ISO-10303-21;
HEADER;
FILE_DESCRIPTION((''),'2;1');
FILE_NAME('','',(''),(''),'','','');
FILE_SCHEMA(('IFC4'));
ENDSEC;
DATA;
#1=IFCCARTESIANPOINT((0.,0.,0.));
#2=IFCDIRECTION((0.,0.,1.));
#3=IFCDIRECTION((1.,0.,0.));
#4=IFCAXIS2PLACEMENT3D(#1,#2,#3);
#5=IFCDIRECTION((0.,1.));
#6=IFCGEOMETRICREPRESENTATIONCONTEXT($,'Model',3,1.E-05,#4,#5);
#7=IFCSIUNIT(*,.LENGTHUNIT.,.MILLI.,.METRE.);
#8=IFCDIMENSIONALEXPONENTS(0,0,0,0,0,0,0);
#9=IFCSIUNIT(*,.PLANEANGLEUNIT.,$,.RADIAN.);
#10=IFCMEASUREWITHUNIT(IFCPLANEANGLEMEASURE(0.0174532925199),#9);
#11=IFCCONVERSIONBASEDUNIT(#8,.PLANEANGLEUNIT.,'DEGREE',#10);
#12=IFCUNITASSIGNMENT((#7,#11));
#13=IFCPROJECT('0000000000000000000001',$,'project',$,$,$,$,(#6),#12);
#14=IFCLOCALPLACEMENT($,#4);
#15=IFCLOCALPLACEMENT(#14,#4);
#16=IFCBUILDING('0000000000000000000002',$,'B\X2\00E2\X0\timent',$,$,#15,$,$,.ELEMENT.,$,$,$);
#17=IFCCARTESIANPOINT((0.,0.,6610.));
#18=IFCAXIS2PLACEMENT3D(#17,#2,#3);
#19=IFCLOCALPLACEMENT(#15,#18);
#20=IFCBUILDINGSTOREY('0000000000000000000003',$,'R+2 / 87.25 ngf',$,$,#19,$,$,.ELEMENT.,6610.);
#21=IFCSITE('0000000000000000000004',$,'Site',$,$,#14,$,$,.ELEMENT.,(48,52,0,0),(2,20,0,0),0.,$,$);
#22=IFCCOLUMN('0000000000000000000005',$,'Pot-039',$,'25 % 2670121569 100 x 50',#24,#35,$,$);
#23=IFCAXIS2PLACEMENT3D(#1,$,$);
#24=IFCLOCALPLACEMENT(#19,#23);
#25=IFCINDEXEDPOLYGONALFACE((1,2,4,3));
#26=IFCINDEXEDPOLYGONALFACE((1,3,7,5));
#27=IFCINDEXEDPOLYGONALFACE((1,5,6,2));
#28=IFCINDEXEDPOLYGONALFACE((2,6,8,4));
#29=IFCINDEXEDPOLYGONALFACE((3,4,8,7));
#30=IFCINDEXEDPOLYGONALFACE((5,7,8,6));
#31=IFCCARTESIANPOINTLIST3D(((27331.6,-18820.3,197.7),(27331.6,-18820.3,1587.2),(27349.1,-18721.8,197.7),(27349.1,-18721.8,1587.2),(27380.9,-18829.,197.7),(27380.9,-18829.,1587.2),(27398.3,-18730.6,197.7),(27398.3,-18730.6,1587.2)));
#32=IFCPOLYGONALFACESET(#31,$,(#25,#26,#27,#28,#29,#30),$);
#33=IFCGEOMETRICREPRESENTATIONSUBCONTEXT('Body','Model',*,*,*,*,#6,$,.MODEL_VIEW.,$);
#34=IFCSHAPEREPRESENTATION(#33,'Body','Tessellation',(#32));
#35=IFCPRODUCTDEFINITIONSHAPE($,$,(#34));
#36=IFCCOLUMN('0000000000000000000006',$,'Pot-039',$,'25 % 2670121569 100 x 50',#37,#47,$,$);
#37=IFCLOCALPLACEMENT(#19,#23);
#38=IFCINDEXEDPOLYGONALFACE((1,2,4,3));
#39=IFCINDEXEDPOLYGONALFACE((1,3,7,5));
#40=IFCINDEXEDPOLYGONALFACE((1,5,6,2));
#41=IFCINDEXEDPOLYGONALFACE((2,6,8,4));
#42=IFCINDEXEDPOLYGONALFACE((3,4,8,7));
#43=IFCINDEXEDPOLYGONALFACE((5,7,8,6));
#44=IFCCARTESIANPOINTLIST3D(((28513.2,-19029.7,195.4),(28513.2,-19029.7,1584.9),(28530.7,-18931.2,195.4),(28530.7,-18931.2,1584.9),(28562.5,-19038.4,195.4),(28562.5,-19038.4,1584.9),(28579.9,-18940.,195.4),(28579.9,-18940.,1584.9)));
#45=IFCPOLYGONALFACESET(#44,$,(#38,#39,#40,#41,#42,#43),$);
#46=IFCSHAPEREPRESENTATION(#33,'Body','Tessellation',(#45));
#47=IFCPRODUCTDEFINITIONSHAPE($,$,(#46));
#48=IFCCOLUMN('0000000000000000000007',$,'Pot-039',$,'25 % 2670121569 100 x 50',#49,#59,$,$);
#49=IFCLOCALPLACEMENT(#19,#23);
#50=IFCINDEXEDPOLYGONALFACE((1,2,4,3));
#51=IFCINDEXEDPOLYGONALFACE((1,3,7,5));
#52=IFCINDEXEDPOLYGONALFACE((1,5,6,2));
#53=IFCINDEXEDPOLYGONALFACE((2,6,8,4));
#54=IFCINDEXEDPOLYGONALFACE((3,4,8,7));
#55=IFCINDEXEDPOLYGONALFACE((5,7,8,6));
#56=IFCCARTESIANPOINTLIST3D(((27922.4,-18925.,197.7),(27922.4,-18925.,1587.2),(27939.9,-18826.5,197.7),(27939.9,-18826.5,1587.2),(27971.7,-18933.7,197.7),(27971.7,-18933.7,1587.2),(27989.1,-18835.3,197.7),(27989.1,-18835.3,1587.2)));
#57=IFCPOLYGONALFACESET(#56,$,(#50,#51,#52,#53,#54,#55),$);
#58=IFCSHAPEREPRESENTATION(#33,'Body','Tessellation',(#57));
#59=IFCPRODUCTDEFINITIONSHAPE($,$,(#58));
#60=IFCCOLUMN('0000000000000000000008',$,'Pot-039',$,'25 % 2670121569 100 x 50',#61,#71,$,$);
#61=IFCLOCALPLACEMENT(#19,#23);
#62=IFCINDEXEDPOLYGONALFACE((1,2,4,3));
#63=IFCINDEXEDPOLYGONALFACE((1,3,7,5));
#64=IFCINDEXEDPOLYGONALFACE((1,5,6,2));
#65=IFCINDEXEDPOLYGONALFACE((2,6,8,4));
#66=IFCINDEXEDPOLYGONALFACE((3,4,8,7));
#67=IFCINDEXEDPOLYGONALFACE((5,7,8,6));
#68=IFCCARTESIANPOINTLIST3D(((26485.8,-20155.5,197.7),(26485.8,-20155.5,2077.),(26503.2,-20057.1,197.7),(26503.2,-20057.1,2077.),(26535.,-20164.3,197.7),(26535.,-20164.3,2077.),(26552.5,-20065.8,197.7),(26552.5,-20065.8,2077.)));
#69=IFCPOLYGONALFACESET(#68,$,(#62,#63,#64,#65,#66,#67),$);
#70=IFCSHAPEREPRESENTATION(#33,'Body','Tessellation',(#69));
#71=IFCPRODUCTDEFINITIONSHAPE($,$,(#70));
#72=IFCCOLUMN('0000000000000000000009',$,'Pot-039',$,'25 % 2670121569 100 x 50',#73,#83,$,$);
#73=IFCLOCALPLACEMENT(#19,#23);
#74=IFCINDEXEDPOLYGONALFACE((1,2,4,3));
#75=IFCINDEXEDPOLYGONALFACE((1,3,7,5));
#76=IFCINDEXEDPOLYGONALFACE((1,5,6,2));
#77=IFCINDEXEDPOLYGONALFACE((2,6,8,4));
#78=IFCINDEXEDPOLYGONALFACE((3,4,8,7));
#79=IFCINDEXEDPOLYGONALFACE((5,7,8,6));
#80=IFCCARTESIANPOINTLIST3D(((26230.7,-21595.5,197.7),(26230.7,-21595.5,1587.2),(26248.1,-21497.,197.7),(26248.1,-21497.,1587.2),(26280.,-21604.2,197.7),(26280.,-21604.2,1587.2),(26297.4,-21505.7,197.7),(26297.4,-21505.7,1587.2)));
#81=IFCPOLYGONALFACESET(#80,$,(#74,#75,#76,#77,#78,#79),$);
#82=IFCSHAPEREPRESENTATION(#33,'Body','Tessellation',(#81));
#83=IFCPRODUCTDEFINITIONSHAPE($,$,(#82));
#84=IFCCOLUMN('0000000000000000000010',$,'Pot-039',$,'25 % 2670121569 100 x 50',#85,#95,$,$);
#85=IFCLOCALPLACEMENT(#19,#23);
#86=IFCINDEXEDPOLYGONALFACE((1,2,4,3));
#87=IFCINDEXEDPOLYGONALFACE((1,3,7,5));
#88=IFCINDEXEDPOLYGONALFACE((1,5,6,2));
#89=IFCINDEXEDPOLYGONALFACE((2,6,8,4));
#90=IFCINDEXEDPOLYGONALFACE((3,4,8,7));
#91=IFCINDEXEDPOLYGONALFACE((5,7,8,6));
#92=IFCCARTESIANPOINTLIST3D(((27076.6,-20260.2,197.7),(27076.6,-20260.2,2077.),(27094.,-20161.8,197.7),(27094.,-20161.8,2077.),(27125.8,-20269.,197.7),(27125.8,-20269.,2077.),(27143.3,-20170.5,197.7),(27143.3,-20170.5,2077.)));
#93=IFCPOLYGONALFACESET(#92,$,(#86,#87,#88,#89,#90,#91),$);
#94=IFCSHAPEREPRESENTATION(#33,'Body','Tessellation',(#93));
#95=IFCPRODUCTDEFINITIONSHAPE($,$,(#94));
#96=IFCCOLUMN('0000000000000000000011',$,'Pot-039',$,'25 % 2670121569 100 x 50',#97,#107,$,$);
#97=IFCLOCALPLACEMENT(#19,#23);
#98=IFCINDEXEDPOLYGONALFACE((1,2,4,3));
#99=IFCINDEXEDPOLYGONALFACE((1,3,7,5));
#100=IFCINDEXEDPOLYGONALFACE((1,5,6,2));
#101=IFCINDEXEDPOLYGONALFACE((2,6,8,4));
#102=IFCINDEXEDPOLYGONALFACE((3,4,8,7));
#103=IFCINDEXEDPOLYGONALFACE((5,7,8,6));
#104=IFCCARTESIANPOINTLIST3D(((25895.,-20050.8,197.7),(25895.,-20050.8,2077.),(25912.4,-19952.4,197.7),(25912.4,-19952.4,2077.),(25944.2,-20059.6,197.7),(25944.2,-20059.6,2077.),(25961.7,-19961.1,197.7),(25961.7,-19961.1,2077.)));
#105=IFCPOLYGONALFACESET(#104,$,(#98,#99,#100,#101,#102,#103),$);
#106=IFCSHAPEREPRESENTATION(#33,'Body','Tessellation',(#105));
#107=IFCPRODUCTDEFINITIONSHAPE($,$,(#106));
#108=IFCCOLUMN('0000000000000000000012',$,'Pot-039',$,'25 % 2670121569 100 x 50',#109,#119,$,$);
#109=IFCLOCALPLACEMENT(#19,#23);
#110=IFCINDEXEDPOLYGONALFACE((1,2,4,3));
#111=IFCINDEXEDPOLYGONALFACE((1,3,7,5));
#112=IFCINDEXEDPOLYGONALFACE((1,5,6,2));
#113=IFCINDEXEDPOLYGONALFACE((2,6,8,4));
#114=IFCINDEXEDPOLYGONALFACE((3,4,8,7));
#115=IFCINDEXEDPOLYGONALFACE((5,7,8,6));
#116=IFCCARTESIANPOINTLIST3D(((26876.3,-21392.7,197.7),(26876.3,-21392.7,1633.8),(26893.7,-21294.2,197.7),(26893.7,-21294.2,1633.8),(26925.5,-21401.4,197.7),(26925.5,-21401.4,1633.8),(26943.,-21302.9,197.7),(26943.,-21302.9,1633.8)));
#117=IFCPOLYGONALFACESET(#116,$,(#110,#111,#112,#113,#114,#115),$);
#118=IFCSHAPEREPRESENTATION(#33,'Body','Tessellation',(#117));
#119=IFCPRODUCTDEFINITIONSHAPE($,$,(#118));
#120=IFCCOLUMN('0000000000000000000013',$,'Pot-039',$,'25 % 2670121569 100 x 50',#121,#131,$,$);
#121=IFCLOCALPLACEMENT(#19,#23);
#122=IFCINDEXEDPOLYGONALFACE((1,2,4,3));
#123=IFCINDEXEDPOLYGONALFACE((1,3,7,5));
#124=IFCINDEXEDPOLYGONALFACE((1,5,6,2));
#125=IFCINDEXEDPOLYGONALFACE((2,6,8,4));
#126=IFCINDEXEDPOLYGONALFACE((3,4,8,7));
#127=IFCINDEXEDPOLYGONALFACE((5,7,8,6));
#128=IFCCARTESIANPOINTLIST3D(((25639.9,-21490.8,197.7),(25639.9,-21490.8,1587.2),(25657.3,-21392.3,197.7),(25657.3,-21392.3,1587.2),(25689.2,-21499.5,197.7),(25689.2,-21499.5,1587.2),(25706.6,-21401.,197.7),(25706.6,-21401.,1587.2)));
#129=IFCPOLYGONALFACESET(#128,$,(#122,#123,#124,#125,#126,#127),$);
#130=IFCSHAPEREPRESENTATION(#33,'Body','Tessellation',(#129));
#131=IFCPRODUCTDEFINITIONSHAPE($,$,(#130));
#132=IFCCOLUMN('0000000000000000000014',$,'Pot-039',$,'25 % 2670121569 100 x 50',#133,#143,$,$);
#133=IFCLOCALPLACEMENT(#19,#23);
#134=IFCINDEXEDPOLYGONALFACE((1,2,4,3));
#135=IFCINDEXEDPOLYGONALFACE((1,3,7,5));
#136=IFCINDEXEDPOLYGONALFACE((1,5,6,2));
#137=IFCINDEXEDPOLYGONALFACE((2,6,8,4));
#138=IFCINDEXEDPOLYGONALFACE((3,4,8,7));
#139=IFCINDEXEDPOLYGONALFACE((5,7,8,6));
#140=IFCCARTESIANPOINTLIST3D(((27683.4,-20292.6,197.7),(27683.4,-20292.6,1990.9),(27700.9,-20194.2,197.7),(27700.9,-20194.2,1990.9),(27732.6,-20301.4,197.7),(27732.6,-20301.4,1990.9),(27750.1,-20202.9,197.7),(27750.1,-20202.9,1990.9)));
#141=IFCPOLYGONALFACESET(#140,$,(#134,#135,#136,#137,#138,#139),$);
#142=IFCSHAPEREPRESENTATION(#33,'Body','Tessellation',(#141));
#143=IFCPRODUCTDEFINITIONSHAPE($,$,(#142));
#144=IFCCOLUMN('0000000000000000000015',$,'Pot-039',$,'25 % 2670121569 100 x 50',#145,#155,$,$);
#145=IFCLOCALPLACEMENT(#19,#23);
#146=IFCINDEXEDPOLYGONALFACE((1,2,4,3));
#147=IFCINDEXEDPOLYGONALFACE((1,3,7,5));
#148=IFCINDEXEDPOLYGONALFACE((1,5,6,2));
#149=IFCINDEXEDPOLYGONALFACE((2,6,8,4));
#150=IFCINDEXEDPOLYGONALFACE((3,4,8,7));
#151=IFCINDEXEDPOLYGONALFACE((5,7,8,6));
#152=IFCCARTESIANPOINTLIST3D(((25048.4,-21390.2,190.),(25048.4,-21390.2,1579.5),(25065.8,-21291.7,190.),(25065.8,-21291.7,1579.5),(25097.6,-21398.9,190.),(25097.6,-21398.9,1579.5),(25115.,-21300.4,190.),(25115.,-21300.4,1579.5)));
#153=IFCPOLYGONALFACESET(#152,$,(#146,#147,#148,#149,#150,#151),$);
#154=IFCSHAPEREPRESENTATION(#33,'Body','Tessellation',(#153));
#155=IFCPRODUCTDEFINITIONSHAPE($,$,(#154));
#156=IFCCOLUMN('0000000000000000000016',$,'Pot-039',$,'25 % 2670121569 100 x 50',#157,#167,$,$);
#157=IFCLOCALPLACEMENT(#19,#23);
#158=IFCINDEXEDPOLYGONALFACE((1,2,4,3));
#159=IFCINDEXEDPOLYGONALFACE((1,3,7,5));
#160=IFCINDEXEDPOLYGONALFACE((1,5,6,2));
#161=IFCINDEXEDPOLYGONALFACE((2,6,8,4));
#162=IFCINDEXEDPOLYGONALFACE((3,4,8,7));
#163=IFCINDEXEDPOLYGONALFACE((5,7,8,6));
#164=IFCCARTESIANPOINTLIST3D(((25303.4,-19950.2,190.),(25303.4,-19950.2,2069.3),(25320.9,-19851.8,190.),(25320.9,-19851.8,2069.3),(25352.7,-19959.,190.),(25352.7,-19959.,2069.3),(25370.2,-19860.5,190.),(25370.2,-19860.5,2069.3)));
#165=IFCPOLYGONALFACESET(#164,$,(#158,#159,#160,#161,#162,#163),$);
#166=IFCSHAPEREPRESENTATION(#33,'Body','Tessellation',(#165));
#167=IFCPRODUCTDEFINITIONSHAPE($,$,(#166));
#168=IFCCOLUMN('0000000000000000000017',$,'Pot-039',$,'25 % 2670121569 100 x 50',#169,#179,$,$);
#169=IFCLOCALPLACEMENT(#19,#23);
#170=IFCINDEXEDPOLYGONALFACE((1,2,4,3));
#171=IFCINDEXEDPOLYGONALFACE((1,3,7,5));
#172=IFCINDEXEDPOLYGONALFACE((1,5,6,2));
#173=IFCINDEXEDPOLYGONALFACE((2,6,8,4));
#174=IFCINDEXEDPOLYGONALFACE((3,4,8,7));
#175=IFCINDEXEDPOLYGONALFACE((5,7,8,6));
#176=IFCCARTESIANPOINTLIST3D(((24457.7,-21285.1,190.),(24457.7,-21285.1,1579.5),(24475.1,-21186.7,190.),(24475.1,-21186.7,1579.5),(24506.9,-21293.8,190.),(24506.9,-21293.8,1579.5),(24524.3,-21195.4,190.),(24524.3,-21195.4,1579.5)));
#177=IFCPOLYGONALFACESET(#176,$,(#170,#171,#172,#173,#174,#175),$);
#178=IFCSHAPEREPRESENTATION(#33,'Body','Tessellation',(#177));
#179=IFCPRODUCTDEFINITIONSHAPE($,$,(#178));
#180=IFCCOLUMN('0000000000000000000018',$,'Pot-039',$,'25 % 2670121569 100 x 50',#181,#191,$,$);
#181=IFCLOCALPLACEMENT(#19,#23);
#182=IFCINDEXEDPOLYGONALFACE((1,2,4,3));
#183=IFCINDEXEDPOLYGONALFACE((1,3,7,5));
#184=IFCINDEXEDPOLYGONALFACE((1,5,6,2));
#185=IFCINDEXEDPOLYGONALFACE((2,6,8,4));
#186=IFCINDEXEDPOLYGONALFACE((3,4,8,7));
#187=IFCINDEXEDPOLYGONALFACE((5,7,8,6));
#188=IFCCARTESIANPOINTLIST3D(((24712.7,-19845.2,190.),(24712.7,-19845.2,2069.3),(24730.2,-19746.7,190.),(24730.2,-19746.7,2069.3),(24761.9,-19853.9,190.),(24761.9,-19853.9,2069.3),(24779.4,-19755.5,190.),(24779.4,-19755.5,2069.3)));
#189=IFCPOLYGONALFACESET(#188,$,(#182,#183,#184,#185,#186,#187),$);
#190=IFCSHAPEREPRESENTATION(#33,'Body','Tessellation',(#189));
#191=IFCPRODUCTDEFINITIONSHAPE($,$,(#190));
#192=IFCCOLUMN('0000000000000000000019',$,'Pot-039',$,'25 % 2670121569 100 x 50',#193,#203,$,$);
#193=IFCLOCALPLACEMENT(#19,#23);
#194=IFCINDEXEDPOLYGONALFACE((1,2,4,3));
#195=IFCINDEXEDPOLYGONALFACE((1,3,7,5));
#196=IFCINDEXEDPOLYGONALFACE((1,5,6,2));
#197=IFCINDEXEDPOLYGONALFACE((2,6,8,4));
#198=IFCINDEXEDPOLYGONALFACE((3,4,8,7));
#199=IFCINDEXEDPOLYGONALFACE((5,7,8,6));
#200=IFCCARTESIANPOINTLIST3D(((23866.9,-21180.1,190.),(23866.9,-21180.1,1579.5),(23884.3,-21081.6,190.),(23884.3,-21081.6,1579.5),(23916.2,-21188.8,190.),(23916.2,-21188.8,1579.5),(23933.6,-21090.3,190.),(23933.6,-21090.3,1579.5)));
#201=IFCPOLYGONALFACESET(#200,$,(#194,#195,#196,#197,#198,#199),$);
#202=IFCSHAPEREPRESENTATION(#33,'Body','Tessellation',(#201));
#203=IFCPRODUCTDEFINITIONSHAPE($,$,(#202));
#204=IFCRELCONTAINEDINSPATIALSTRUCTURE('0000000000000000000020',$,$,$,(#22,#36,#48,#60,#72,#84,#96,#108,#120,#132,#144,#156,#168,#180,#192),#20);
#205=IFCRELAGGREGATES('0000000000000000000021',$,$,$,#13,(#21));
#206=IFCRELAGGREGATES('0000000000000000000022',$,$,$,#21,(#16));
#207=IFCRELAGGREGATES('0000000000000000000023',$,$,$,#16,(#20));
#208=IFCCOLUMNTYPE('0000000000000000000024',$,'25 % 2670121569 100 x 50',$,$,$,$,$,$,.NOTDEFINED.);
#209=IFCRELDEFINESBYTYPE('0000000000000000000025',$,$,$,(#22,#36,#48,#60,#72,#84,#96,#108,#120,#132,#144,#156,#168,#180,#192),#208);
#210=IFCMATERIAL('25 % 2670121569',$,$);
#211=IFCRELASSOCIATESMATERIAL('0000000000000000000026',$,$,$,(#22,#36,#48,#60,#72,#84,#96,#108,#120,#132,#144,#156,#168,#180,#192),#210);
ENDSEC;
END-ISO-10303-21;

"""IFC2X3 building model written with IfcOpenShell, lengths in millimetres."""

from ifc_helpers import new_model, entity, si_unit, converted_unit, direction, frame, origin_with_axes, origin_2d_with_axis, place, context, subcontext, project, spatial, rectangle, extrude, material, type_object, element, save


model = new_model("IFC2X3")

# Units and contexts
model_context = context("Model", 3, precision=1e-05, world=origin_with_axes(), true_north=direction((0.0, 1.0)))
body_context = subcontext(model_context, "Body", "Model", "MODEL_VIEW")
ifc_project = project(units=[si_unit("LENGTHUNIT", "METRE", prefix="MILLI"), converted_unit("PLANEANGLEUNIT", "DEGREE", entity("IfcPlaneAngleMeasure", 0.0174532925199), si_unit("PLANEANGLEUNIT", "RADIAN"), dimensions=[0, 0, 0, 0, 0, 0, 0])], contexts=[model_context])

# Site, building, storey
site_placement = place(None, origin_with_axes())
site = spatial("IfcSite", under=ifc_project, at=site_placement, Name="Site", CompositionType="ELEMENT", RefLatitude=(48, 52, 0, 0), RefLongitude=(2, 20, 0, 0), RefElevation=0.0)
building_placement = place(site_placement, origin_with_axes())
building = spatial("IfcBuilding", under=site, at=building_placement, Name="Bâtiment", CompositionType="ELEMENT")
storey_placement = place(building_placement, frame((0.0, 0.0, 6610.0), z_axis=(0.0, 0.0, 1.0), x_axis=(1.0, 0.0, 0.0)))
storey = spatial("IfcBuildingStorey", under=building, at=storey_placement, Name="R+2 / 87.25 ngf", CompositionType="ELEMENT", Elevation=6610.0)

# Columns
ifc_material_1 = material(Name="25 % 2670121569")
column_type = type_object("IfcColumnType", Name="25 % 2670121569 100 x 50", PredefinedType="NOTDEFINED")
for number, where, z_axis, x_axis, name in (
    (1, (27365.0, -18775.4, 197.7), (0.0, 0.0, 1.0), (0.17478, 0.984607, 0.0), "Pot-039"),
    (2, (28546.6, -18984.8, 195.4), (0.0, 0.0, 1.0), (0.17478, 0.984607, 0.0), "Pot-039"),
    (3, (27955.8, -18880.1, 197.7), (0.0, 0.0, 1.0), (0.17478, 0.984607, 0.0), "Pot-039"),
):
    element("IfcColumn", number, at=place(storey_placement, frame(where, z_axis=z_axis, x_axis=x_axis)), inside=storey, type_object=column_type, material=ifc_material_1, Name=name, ObjectType="25 % 2670121569 100 x 50", context=body_context, shape_type="SweptSolid", body=[
        extrude(rectangle(XDim=100.0, YDim=50.0, at=origin_2d_with_axis()), origin_with_axes(), (0.0, 0.0, 1.0), 1389.5),
    ])
column_1_placement = place(storey_placement, frame((26519.1, -20110.7, 197.7), z_axis=(0.0, 0.0, 1.0), x_axis=(0.17478, 0.984607, 0.0)))
element("IfcColumn", 4, at=column_1_placement, inside=storey, type_object=column_type, material=ifc_material_1, Name="Pot-039", ObjectType="25 % 2670121569 100 x 50", context=body_context, shape_type="SweptSolid", body=[
    extrude(rectangle(XDim=100.0, YDim=50.0, at=origin_2d_with_axis()), origin_with_axes(), (0.0, 0.0, 1.0), 1879.3),
])
column_2_placement = place(storey_placement, frame((26264.0, -21550.6, 197.7), z_axis=(0.0, 0.0, 1.0), x_axis=(0.17408, 0.984731, 0.0)))
element("IfcColumn", 5, at=column_2_placement, inside=storey, type_object=column_type, material=ifc_material_1, Name="Pot-039", ObjectType="25 % 2670121569 100 x 50", context=body_context, shape_type="SweptSolid", body=[
    extrude(rectangle(XDim=100.0, YDim=50.0, at=origin_2d_with_axis()), origin_with_axes(), (0.0, 0.0, 1.0), 1389.5),
])
for number, where, z_axis, x_axis, name in (
    (6, (27109.9, -20215.4, 197.7), (0.0, 0.0, 1.0), (0.17478, 0.984607, 0.0), "Pot-039"),
    (7, (25928.3, -20006.0, 197.7), (0.0, 0.0, 1.0), (0.17478, 0.984607, 0.0), "Pot-039"),
):
    element("IfcColumn", number, at=place(storey_placement, frame(where, z_axis=z_axis, x_axis=x_axis)), inside=storey, type_object=column_type, material=ifc_material_1, Name=name, ObjectType="25 % 2670121569 100 x 50", context=body_context, shape_type="SweptSolid", body=[
        extrude(rectangle(XDim=100.0, YDim=50.0, at=origin_2d_with_axis()), origin_with_axes(), (0.0, 0.0, 1.0), 1879.3),
    ])
column_3_placement = place(storey_placement, frame((26909.6, -21347.8, 197.7), z_axis=(0.0, 0.0, 1.0), x_axis=(0.17408, 0.984731, 0.0)))
element("IfcColumn", 8, at=column_3_placement, inside=storey, type_object=column_type, material=ifc_material_1, Name="Pot-039", ObjectType="25 % 2670121569 100 x 50", context=body_context, shape_type="SweptSolid", body=[
    extrude(rectangle(XDim=100.0, YDim=50.0, at=origin_2d_with_axis()), origin_with_axes(), (0.0, 0.0, 1.0), 1436.0),
])
column_4_placement = place(storey_placement, frame((25673.2, -21445.9, 197.7), z_axis=(0.0, 0.0, 1.0), x_axis=(0.17408, 0.984731, 0.0)))
element("IfcColumn", 9, at=column_4_placement, inside=storey, type_object=column_type, material=ifc_material_1, Name="Pot-039", ObjectType="25 % 2670121569 100 x 50", context=body_context, shape_type="SweptSolid", body=[
    extrude(rectangle(XDim=100.0, YDim=50.0, at=origin_2d_with_axis()), origin_with_axes(), (0.0, 0.0, 1.0), 1389.5),
])
column_5_placement = place(storey_placement, frame((27716.7, -20247.8, 197.7), z_axis=(0.0, 0.0, 1.0), x_axis=(0.17478, 0.984607, 0.0)))
element("IfcColumn", 10, at=column_5_placement, inside=storey, type_object=column_type, material=ifc_material_1, Name="Pot-039", ObjectType="25 % 2670121569 100 x 50", context=body_context, shape_type="SweptSolid", body=[
    extrude(rectangle(XDim=100.0, YDim=50.0, at=origin_2d_with_axis()), origin_with_axes(), (0.0, 0.0, 1.0), 1793.2),
])
column_6_placement = place(storey_placement, frame((25081.7, -21345.3, 190.0), z_axis=(0.0, 0.0, 1.0), x_axis=(0.17408, 0.984731, 0.0)))
element("IfcColumn", 11, at=column_6_placement, inside=storey, type_object=column_type, material=ifc_material_1, Name="Pot-039", ObjectType="25 % 2670121569 100 x 50", context=body_context, shape_type="SweptSolid", body=[
    extrude(rectangle(XDim=100.0, YDim=50.0, at=origin_2d_with_axis()), origin_with_axes(), (0.0, 0.0, 1.0), 1389.5),
])
column_7_placement = place(storey_placement, frame((25336.8, -19905.4, 190.0), z_axis=(0.0, 0.0, 1.0), x_axis=(0.17478, 0.984607, 0.0)))
element("IfcColumn", 12, at=column_7_placement, inside=storey, type_object=column_type, material=ifc_material_1, Name="Pot-039", ObjectType="25 % 2670121569 100 x 50", context=body_context, shape_type="SweptSolid", body=[
    extrude(rectangle(XDim=100.0, YDim=50.0, at=origin_2d_with_axis()), origin_with_axes(), (0.0, 0.0, 1.0), 1879.3),
])
column_8_placement = place(storey_placement, frame((24491.0, -21240.3, 190.0), z_axis=(0.0, 0.0, 1.0), x_axis=(0.17408, 0.984731, 0.0)))
element("IfcColumn", 13, at=column_8_placement, inside=storey, type_object=column_type, material=ifc_material_1, Name="Pot-039", ObjectType="25 % 2670121569 100 x 50", context=body_context, shape_type="SweptSolid", body=[
    extrude(rectangle(XDim=100.0, YDim=50.0, at=origin_2d_with_axis()), origin_with_axes(), (0.0, 0.0, 1.0), 1389.5),
])
column_9_placement = place(storey_placement, frame((24746.1, -19800.3, 190.0), z_axis=(0.0, 0.0, 1.0), x_axis=(0.17478, 0.984607, 0.0)))
element("IfcColumn", 14, at=column_9_placement, inside=storey, type_object=column_type, material=ifc_material_1, Name="Pot-039", ObjectType="25 % 2670121569 100 x 50", context=body_context, shape_type="SweptSolid", body=[
    extrude(rectangle(XDim=100.0, YDim=50.0, at=origin_2d_with_axis()), origin_with_axes(), (0.0, 0.0, 1.0), 1879.3),
])
column_10_placement = place(storey_placement, frame((23900.3, -21135.2, 190.0), z_axis=(0.0, 0.0, 1.0), x_axis=(0.17408, 0.984731, 0.0)))
element("IfcColumn", 15, at=column_10_placement, inside=storey, type_object=column_type, material=ifc_material_1, Name="Pot-039", ObjectType="25 % 2670121569 100 x 50", context=body_context, shape_type="SweptSolid", body=[
    extrude(rectangle(XDim=100.0, YDim=50.0, at=origin_2d_with_axis()), origin_with_axes(), (0.0, 0.0, 1.0), 1389.5),
])

save(model, "model.ifc")
